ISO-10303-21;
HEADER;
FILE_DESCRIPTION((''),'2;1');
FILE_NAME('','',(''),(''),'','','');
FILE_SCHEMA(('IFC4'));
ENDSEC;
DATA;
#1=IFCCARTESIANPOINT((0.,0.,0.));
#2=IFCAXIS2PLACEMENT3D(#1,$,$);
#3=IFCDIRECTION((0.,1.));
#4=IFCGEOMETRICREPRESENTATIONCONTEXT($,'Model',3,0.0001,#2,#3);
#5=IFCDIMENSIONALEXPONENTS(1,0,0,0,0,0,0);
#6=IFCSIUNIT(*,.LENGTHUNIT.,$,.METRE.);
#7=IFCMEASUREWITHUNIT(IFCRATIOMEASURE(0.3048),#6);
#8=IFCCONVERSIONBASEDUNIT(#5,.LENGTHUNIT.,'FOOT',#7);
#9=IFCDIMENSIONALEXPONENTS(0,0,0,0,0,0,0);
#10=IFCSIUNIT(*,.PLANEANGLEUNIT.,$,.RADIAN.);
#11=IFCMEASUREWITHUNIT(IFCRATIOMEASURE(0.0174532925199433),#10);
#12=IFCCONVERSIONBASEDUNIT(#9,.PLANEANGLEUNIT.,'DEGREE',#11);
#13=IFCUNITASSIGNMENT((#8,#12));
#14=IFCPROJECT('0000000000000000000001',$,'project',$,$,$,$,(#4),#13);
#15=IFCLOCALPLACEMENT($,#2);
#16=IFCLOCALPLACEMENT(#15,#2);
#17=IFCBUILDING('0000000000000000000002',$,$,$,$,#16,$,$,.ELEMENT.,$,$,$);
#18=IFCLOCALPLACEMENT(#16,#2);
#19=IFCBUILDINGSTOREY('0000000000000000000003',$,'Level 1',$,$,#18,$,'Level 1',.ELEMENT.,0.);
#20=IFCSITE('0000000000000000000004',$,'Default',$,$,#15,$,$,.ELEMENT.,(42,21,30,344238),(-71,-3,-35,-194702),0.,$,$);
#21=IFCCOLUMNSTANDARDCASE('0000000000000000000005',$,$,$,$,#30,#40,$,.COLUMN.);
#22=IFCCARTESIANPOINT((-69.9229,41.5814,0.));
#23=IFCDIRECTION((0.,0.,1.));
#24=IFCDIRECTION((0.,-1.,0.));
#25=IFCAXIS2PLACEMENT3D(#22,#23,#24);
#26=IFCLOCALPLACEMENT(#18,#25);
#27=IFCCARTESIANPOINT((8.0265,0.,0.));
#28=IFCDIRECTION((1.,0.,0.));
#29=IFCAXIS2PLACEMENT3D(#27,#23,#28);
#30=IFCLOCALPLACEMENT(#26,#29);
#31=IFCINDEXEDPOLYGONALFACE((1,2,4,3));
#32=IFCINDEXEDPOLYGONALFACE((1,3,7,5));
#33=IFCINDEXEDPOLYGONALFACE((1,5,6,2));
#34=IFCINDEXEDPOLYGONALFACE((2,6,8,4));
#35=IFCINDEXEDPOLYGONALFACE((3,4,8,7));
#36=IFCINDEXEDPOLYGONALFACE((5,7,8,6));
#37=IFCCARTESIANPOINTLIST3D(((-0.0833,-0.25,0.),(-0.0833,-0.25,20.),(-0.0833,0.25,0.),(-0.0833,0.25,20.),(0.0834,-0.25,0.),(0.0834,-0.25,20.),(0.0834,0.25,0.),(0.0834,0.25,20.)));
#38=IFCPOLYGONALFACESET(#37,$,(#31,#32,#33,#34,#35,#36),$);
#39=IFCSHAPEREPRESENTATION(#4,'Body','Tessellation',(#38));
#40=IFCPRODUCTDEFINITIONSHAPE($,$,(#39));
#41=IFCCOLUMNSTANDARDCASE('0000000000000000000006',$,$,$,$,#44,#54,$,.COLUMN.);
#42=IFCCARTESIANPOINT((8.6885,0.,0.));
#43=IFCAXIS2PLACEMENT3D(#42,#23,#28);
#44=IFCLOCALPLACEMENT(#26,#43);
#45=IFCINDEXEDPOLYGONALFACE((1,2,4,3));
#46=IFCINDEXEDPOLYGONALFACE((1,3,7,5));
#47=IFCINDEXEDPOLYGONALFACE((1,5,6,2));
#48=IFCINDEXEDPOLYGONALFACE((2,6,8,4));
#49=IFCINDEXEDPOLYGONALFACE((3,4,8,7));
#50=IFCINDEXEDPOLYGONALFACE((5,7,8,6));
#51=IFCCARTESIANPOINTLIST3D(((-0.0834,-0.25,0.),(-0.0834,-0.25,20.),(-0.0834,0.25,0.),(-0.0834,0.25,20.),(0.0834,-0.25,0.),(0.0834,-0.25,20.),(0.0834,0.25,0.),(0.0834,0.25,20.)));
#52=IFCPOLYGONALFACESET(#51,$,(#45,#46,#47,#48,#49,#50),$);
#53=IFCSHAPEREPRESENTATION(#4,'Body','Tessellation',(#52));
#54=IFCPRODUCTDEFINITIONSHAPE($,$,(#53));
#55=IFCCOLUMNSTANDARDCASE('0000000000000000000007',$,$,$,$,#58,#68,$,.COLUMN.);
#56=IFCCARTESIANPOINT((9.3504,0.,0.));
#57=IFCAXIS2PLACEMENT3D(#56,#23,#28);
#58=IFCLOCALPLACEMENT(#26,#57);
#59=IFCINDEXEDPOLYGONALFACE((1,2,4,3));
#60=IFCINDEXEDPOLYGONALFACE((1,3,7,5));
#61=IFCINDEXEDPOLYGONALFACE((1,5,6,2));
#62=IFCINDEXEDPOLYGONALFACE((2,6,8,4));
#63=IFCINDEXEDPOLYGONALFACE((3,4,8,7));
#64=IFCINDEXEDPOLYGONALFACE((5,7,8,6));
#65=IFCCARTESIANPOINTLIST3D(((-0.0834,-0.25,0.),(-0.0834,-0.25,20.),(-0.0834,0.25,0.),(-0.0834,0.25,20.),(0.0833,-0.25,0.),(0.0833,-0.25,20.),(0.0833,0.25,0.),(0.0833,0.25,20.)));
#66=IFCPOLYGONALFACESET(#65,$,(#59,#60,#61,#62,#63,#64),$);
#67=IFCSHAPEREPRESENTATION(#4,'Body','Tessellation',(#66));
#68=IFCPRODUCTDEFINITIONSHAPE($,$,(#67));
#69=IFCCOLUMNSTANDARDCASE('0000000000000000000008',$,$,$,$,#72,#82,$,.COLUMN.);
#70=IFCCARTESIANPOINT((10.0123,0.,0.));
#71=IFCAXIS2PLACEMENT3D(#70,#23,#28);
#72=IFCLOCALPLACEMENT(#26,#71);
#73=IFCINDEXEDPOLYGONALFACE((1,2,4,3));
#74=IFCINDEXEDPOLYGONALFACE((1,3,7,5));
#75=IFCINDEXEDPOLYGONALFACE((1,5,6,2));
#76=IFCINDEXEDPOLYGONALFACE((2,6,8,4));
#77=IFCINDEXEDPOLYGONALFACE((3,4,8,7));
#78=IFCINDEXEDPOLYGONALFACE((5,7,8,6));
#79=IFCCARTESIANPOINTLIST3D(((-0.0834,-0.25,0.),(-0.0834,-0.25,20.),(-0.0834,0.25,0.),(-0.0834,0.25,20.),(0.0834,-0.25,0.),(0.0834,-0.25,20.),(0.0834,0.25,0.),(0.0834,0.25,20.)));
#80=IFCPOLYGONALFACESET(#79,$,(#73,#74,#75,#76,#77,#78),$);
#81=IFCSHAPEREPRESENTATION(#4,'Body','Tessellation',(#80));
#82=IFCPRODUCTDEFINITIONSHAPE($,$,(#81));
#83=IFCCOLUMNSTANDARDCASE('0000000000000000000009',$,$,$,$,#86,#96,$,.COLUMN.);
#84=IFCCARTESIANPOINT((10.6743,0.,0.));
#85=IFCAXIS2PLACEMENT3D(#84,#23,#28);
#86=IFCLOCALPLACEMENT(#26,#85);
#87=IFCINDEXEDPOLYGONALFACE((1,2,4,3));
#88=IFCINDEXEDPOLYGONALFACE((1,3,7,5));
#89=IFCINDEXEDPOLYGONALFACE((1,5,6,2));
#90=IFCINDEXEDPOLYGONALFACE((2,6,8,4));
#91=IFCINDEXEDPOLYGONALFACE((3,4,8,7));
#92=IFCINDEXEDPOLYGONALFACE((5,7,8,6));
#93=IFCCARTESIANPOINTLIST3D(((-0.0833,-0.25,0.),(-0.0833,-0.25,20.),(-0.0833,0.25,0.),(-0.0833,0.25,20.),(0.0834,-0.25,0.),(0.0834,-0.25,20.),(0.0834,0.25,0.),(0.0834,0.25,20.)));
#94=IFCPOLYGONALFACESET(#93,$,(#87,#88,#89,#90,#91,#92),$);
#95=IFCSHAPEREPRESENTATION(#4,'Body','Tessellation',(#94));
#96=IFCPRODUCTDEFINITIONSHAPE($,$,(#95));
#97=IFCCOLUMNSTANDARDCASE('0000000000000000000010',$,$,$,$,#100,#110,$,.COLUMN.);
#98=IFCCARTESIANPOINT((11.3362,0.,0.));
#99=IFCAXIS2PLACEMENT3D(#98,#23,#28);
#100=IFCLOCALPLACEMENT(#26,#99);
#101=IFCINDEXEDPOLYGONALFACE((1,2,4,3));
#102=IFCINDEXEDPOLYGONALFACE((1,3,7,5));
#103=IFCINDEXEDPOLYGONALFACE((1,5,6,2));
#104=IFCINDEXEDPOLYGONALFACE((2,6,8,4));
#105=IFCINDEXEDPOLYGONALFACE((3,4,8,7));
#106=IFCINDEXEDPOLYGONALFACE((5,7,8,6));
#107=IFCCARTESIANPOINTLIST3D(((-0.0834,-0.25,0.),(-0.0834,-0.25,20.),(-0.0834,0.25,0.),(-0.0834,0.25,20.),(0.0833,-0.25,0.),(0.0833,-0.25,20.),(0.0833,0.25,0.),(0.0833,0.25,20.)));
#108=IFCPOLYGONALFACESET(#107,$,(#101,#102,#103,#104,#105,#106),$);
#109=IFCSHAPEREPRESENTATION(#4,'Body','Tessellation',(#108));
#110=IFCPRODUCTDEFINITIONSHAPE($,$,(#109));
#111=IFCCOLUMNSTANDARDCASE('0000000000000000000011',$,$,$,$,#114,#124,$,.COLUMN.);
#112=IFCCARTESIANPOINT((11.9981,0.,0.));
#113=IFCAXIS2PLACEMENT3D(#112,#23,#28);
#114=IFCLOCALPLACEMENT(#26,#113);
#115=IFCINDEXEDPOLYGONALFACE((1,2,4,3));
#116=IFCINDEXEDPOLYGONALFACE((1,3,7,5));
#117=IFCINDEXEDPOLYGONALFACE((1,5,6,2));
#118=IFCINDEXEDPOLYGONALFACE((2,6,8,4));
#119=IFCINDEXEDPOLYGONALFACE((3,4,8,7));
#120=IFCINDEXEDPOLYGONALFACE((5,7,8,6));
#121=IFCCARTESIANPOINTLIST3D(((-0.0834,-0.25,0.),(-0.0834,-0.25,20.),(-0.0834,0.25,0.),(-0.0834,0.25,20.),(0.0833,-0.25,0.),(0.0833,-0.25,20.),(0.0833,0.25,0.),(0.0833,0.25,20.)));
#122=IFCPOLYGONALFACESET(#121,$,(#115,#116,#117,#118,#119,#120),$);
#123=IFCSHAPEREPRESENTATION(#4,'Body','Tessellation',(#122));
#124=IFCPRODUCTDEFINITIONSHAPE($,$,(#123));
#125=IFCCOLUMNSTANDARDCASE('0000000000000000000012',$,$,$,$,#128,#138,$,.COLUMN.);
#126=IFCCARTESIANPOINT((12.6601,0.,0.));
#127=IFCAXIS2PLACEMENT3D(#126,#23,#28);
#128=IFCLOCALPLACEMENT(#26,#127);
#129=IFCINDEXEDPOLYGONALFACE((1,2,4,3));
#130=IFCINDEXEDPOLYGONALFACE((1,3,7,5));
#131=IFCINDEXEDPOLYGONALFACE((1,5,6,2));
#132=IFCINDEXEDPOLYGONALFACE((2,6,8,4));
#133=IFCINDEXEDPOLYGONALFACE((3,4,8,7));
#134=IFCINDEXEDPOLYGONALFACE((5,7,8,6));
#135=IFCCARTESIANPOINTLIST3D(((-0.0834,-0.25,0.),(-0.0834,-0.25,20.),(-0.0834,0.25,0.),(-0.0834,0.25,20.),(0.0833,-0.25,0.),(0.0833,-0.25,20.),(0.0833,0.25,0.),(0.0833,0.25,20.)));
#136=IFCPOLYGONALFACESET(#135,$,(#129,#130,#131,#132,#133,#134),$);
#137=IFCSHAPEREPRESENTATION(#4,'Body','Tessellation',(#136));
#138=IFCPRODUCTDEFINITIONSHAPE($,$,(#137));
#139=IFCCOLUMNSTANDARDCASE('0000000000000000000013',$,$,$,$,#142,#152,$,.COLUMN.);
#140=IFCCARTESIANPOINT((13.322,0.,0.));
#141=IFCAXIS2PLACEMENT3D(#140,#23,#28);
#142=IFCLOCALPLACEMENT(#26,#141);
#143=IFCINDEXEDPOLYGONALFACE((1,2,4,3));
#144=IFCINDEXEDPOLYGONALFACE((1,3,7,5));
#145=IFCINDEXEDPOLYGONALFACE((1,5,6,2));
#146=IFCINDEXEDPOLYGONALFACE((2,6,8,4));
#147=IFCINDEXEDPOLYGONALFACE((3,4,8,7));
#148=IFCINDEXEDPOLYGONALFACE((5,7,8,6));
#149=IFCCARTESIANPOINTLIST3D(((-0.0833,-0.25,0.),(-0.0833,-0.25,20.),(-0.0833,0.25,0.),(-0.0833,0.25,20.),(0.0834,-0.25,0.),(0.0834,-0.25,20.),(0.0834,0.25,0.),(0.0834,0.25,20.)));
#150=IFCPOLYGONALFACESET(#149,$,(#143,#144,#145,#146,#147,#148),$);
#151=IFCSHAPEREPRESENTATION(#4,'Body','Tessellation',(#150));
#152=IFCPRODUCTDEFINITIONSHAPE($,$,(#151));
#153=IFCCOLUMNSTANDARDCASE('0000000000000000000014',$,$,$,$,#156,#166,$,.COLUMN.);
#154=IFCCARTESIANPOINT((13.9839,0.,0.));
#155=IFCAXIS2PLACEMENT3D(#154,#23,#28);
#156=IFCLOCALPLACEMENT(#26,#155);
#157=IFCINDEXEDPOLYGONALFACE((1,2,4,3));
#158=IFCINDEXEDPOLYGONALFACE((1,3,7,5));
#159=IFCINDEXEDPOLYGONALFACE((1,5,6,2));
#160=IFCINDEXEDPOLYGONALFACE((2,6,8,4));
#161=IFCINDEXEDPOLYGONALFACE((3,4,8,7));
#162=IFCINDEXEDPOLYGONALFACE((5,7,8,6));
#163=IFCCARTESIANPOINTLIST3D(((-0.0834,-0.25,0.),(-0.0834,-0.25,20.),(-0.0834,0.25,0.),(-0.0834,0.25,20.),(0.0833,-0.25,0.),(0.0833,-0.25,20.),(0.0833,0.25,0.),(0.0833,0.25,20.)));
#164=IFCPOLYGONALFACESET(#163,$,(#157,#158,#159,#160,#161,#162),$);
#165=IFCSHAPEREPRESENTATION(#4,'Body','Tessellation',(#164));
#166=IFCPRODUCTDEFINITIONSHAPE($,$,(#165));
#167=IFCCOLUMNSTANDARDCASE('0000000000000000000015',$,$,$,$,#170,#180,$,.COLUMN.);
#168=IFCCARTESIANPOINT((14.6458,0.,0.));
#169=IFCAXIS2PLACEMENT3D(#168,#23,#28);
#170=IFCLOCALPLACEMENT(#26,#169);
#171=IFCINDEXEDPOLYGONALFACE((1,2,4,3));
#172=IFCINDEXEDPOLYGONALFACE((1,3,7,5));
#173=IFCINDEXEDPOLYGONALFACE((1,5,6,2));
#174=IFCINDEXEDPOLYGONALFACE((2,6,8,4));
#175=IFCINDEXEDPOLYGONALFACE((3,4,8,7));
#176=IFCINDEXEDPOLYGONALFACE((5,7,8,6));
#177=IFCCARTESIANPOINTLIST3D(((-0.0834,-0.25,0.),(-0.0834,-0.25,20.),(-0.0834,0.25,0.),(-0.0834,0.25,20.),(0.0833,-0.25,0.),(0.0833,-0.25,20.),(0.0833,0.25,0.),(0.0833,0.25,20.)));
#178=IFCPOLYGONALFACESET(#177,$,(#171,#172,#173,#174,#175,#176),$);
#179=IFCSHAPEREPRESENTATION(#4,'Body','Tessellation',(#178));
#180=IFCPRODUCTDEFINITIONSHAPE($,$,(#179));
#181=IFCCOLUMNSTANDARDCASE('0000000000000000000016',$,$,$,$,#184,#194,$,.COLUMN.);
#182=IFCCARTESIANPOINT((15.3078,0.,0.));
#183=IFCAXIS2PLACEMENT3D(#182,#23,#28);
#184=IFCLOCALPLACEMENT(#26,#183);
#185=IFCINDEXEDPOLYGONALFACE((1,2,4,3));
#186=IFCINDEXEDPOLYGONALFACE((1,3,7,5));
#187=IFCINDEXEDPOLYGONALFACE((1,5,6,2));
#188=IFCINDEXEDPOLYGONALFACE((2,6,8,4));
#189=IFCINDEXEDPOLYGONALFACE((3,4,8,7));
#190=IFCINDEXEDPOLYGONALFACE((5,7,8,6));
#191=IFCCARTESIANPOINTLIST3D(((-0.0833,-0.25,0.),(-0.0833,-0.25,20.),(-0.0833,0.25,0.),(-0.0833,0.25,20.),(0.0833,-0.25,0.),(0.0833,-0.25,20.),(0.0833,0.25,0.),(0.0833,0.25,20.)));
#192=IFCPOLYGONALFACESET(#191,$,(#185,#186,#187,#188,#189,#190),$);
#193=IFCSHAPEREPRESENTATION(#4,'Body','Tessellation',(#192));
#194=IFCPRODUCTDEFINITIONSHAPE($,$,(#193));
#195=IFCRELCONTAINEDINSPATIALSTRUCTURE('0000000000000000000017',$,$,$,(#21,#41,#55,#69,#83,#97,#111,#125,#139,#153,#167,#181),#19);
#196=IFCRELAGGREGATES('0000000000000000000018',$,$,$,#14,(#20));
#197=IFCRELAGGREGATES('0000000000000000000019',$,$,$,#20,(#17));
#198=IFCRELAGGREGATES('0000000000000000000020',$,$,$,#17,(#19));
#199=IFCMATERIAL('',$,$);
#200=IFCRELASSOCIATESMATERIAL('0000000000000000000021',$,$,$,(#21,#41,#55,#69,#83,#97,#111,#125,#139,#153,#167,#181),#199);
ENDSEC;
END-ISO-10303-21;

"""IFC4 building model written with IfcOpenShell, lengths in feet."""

from ifc_helpers import new_model, entity, si_unit, converted_unit, direction, frame, origin, place, context, project, spatial, rectangle, extrude, material, element, save


model = new_model("IFC4")

# Units and contexts
model_context = context("Model", 3, precision=0.0001, world=origin(), true_north=direction((0.0, 1.0)))
ifc_project = project(units=[converted_unit("LENGTHUNIT", "FOOT", entity("IfcRatioMeasure", 0.3048), si_unit("LENGTHUNIT", "METRE"), dimensions=[1, 0, 0, 0, 0, 0, 0]), converted_unit("PLANEANGLEUNIT", "DEGREE", entity("IfcRatioMeasure", 0.0174532925199433), si_unit("PLANEANGLEUNIT", "RADIAN"), dimensions=[0, 0, 0, 0, 0, 0, 0])], contexts=[model_context])

# Site, building, storey
site_placement = place(None, origin())
site = spatial("IfcSite", under=ifc_project, at=site_placement, Name="Default", CompositionType="ELEMENT", RefLatitude=(42, 21, 30, 344238), RefLongitude=(-71, -3, -35, -194702), RefElevation=0.0)
building_placement = place(site_placement, origin())
building = spatial("IfcBuilding", under=site, at=building_placement, CompositionType="ELEMENT")
storey_placement = place(building_placement, origin())
storey = spatial("IfcBuildingStorey", under=building, at=storey_placement, Name="Level 1", LongName="Level 1", CompositionType="ELEMENT", Elevation=0.0)

# Columns
ifc_material_1 = material(Name="")
placement_1 = place(storey_placement, frame((-69.9229, 41.5814, 0.0), z_axis=(0.0, 0.0, 1.0), x_axis=(0.0, -1.0, 0.0)))
for number, where, z_axis, x_axis in (
    (1, (8.0265, 0.0, 0.0), (0.0, 0.0, 1.0), (1.0, 0.0, 0.0)),
    (2, (8.6885, 0.0, 0.0), (0.0, 0.0, 1.0), (1.0, 0.0, 0.0)),
    (3, (9.3504, 0.0, 0.0), (0.0, 0.0, 1.0), (1.0, 0.0, 0.0)),
    (4, (10.0123, 0.0, 0.0), (0.0, 0.0, 1.0), (1.0, 0.0, 0.0)),
    (5, (10.6743, 0.0, 0.0), (0.0, 0.0, 1.0), (1.0, 0.0, 0.0)),
    (6, (11.3362, 0.0, 0.0), (0.0, 0.0, 1.0), (1.0, 0.0, 0.0)),
    (7, (11.9981, 0.0, 0.0), (0.0, 0.0, 1.0), (1.0, 0.0, 0.0)),
    (8, (12.6601, 0.0, 0.0), (0.0, 0.0, 1.0), (1.0, 0.0, 0.0)),
    (9, (13.322, 0.0, 0.0), (0.0, 0.0, 1.0), (1.0, 0.0, 0.0)),
    (10, (13.9839, 0.0, 0.0), (0.0, 0.0, 1.0), (1.0, 0.0, 0.0)),
    (11, (14.6458, 0.0, 0.0), (0.0, 0.0, 1.0), (1.0, 0.0, 0.0)),
    (12, (15.3078, 0.0, 0.0), (0.0, 0.0, 1.0), (1.0, 0.0, 0.0)),
):
    element("IfcColumnStandardCase", number, at=place(placement_1, frame(where, z_axis=z_axis, x_axis=x_axis)), inside=storey, material=ifc_material_1, PredefinedType="COLUMN", context=model_context, shape_type="SweptSolid", body=[
        extrude(rectangle(XDim=0.1667, YDim=0.5), origin(), (0.0, 0.0, 1.0), 20.0),
    ])

save(model, "model.ifc")
